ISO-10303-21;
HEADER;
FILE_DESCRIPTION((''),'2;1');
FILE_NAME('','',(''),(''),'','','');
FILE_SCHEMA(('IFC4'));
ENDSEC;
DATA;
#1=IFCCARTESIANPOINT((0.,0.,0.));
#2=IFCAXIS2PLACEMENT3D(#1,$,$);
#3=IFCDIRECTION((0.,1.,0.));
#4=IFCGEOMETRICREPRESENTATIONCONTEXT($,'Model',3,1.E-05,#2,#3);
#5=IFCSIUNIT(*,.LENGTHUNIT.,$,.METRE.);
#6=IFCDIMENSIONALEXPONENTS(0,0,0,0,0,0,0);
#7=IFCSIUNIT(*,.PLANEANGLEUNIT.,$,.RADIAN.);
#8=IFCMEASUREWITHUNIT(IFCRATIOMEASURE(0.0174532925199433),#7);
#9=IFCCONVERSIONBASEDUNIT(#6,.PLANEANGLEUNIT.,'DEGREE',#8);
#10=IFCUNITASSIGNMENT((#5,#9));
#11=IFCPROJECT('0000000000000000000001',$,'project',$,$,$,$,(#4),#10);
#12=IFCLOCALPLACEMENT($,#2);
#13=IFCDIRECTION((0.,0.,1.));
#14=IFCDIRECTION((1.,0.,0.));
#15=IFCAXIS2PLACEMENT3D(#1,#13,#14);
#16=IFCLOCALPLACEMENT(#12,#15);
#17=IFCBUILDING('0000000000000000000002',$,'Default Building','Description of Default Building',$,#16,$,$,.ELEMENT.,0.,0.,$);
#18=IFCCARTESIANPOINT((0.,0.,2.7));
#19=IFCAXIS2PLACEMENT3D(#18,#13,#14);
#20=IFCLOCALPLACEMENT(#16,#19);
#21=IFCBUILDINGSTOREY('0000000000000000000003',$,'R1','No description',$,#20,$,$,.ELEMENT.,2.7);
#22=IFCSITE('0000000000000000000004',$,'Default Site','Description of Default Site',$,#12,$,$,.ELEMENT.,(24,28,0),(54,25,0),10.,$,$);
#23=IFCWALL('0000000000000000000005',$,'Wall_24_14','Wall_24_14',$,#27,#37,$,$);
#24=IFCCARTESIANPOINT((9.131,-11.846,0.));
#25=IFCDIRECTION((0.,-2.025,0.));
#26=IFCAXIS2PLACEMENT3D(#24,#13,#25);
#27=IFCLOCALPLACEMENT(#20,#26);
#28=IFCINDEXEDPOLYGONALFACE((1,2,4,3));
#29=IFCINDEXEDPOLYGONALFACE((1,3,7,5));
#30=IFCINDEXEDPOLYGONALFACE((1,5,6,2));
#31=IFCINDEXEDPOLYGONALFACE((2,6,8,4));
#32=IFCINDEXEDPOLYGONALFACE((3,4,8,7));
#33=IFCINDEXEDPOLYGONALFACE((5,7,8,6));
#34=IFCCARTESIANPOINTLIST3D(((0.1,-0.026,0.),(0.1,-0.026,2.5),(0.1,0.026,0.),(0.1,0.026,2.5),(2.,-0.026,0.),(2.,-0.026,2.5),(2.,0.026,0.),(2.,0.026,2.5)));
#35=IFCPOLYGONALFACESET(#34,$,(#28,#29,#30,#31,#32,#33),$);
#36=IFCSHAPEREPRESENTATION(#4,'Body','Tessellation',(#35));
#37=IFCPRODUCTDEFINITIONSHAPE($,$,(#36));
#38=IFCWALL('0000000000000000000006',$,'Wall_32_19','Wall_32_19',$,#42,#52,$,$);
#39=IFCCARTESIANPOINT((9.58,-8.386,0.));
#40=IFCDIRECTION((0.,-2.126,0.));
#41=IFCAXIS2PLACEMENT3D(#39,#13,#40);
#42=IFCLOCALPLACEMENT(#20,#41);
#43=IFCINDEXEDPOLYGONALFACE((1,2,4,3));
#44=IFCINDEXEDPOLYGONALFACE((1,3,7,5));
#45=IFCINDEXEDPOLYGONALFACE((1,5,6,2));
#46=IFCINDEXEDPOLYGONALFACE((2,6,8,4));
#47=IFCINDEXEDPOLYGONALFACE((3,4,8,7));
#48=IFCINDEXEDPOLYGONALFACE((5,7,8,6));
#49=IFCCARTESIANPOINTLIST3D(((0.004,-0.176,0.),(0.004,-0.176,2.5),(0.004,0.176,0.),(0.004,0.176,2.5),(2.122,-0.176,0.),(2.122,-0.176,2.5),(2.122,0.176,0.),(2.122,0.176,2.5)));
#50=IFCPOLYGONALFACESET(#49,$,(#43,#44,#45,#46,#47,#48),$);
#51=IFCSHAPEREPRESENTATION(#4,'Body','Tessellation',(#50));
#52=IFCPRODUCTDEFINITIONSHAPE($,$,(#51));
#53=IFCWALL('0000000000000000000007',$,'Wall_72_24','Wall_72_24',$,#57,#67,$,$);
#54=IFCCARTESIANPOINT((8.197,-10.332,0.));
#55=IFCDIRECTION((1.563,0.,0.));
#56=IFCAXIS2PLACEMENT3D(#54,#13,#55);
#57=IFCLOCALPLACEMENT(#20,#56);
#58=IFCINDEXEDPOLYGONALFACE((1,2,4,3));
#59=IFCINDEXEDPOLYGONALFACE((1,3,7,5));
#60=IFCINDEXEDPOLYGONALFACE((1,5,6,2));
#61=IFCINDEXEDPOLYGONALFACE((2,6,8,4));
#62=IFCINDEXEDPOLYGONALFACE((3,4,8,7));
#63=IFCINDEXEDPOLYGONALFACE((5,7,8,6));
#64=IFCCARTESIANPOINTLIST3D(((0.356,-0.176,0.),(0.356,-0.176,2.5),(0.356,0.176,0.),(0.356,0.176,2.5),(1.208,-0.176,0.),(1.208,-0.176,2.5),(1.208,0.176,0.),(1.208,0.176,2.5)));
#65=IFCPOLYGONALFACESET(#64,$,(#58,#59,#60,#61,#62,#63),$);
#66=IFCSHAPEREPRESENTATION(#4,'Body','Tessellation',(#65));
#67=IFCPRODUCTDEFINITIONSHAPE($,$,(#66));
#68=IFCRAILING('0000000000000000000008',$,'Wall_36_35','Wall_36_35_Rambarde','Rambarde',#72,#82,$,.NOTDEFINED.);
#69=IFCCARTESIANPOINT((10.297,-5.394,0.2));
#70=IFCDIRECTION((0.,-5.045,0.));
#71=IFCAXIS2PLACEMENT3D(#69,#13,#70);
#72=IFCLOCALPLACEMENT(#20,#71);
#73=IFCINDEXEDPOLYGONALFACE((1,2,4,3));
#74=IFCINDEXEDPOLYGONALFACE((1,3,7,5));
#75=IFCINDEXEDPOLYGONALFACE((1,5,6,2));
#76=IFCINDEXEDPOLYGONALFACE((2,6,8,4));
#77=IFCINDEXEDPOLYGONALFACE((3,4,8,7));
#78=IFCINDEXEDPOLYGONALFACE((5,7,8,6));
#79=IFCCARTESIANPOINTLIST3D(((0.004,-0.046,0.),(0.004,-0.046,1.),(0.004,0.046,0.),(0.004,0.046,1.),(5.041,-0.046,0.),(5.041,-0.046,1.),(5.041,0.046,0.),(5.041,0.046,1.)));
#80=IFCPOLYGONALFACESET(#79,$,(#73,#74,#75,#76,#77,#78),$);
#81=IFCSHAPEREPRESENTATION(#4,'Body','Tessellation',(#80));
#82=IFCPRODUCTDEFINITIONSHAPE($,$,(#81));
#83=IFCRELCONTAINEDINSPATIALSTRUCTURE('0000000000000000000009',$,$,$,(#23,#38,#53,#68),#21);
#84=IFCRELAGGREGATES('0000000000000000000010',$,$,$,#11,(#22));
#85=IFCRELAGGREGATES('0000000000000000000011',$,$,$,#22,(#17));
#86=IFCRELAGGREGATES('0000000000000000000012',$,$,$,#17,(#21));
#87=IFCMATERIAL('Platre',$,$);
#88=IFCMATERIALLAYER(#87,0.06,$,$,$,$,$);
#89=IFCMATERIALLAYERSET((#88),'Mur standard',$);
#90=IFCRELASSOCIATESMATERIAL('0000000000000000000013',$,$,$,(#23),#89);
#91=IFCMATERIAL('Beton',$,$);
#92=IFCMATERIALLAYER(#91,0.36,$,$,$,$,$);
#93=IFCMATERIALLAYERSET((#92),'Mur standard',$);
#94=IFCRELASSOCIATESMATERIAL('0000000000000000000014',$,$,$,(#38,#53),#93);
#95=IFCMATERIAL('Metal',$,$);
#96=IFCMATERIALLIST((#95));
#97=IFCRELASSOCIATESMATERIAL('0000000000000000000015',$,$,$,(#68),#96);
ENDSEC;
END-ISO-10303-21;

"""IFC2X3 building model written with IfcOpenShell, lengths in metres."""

from ifc_helpers import new_model, entity, si_unit, converted_unit, direction, frame, origin, origin_with_axes, place, context, project, spatial, polyline, outline, extrude, material, material_list, layer, layer_set, layer_usage, element, save


model = new_model("IFC2X3")

# Units and contexts
model_context = context("Model", 3, precision=1e-05, world=origin(), true_north=direction((0.0, 1.0, 0.0)))
ifc_project = project(units=[si_unit("LENGTHUNIT", "METRE"), converted_unit("PLANEANGLEUNIT", "DEGREE", entity("IfcRatioMeasure", 0.0174532925199433), si_unit("PLANEANGLEUNIT", "RADIAN"), dimensions=[0, 0, 0, 0, 0, 0, 0])], contexts=[model_context])

# Site, building, storey
site_placement = place(None, origin())
site = spatial("IfcSite", under=ifc_project, at=site_placement, Name="Default Site", Description="Description of Default Site", CompositionType="ELEMENT", RefLatitude=(24, 28, 0), RefLongitude=(54, 25, 0), RefElevation=10.0)
building_placement = place(site_placement, origin_with_axes())
building = spatial("IfcBuilding", under=site, at=building_placement, Name="Default Building", Description="Description of Default Building", CompositionType="ELEMENT", ElevationOfRefHeight=0.0, ElevationOfTerrain=0.0)
storey_placement = place(building_placement, frame((0.0, 0.0, 2.7), z_axis=(0.0, 0.0, 1.0), x_axis=(1.0, 0.0, 0.0)))
storey = spatial("IfcBuildingStorey", under=building, at=storey_placement, Name="R1", Description="No description", CompositionType="ELEMENT", Elevation=2.7)

# Shared definitions
ifc_material_1 = material(Name="Beton")
ifc_layer_1 = layer(ifc_material_1, 0.36)
ifc_layer_set_1 = layer_set([ifc_layer_1], Name="Mur standard")
ifc_layer_usage_1 = layer_usage(ifc_layer_set_1, "AXIS2", "NEGATIVE", 0.36)

# Shared definitions
ifc_material_2 = material(Name="Platre")
ifc_layer_2 = layer(ifc_material_2, 0.06)
ifc_layer_set_2 = layer_set([ifc_layer_2], Name="Mur standard")
ifc_layer_usage_2 = layer_usage(ifc_layer_set_2, "AXIS2", "NEGATIVE", 0.06)

# Wall
wall_1_placement = place(storey_placement, frame((9.131, -11.846, 0.0), z_axis=(0.0, 0.0, 1.0), x_axis=(0.0, -2.025, 0.0)))
element("IfcWall", 1, at=wall_1_placement, inside=storey, material=ifc_layer_usage_2, Name="Wall_24_14", Description="Wall_24_14", context=model_context, shape_type="SweptSolid", body=[
    extrude(outline(polyline([(0.1, -0.026), (2.0, -0.026), (2.0, 0.026), (0.1, 0.026), (0.1, -0.026)])), origin(), (0.0, 0.0, 1.0), 2.5),
])

# Walls
wall_2_placement = place(storey_placement, frame((9.58, -8.386, 0.0), z_axis=(0.0, 0.0, 1.0), x_axis=(0.0, -2.126, 0.0)))
element("IfcWall", 2, at=wall_2_placement, inside=storey, material=ifc_layer_usage_1, Name="Wall_32_19", Description="Wall_32_19", context=model_context, shape_type="SweptSolid", body=[
    extrude(outline(polyline([(0.004, -0.176), (2.122, -0.176), (2.122, 0.176), (0.004, 0.176), (0.004, -0.176)])), origin(), (0.0, 0.0, 1.0), 2.5),
])
wall_3_placement = place(storey_placement, frame((8.197, -10.332, 0.0), z_axis=(0.0, 0.0, 1.0), x_axis=(1.563, 0.0, 0.0)))
element("IfcWall", 3, at=wall_3_placement, inside=storey, material=ifc_layer_usage_1, Name="Wall_72_24", Description="Wall_72_24", context=model_context, shape_type="SweptSolid", body=[
    extrude(outline(polyline([(0.356, 0.176), (0.356, -0.176), (1.208, -0.176), (1.208, 0.176), (0.356, 0.176)])), origin(), (0.0, 0.0, 1.0), 2.5),
])

# Railing
ifc_material_3 = material(Name="Metal")
ifc_material_list_1 = material_list([ifc_material_3])
railing_placement = place(storey_placement, frame((10.297, -5.394, 0.2), z_axis=(0.0, 0.0, 1.0), x_axis=(0.0, -5.045, 0.0)))
element("IfcRailing", 4, at=railing_placement, inside=storey, material=ifc_material_list_1, Name="Wall_36_35", Description="Wall_36_35_Rambarde", ObjectType="Rambarde", PredefinedType="NOTDEFINED", context=model_context, shape_type="SweptSolid", body=[
    extrude(outline(polyline([(0.004, -0.046), (5.041, -0.046), (5.041, 0.046), (0.004, 0.046), (0.004, -0.046)])), origin(), (0.0, 0.0, 1.0), 1.0),
])

save(model, "model.ifc")
